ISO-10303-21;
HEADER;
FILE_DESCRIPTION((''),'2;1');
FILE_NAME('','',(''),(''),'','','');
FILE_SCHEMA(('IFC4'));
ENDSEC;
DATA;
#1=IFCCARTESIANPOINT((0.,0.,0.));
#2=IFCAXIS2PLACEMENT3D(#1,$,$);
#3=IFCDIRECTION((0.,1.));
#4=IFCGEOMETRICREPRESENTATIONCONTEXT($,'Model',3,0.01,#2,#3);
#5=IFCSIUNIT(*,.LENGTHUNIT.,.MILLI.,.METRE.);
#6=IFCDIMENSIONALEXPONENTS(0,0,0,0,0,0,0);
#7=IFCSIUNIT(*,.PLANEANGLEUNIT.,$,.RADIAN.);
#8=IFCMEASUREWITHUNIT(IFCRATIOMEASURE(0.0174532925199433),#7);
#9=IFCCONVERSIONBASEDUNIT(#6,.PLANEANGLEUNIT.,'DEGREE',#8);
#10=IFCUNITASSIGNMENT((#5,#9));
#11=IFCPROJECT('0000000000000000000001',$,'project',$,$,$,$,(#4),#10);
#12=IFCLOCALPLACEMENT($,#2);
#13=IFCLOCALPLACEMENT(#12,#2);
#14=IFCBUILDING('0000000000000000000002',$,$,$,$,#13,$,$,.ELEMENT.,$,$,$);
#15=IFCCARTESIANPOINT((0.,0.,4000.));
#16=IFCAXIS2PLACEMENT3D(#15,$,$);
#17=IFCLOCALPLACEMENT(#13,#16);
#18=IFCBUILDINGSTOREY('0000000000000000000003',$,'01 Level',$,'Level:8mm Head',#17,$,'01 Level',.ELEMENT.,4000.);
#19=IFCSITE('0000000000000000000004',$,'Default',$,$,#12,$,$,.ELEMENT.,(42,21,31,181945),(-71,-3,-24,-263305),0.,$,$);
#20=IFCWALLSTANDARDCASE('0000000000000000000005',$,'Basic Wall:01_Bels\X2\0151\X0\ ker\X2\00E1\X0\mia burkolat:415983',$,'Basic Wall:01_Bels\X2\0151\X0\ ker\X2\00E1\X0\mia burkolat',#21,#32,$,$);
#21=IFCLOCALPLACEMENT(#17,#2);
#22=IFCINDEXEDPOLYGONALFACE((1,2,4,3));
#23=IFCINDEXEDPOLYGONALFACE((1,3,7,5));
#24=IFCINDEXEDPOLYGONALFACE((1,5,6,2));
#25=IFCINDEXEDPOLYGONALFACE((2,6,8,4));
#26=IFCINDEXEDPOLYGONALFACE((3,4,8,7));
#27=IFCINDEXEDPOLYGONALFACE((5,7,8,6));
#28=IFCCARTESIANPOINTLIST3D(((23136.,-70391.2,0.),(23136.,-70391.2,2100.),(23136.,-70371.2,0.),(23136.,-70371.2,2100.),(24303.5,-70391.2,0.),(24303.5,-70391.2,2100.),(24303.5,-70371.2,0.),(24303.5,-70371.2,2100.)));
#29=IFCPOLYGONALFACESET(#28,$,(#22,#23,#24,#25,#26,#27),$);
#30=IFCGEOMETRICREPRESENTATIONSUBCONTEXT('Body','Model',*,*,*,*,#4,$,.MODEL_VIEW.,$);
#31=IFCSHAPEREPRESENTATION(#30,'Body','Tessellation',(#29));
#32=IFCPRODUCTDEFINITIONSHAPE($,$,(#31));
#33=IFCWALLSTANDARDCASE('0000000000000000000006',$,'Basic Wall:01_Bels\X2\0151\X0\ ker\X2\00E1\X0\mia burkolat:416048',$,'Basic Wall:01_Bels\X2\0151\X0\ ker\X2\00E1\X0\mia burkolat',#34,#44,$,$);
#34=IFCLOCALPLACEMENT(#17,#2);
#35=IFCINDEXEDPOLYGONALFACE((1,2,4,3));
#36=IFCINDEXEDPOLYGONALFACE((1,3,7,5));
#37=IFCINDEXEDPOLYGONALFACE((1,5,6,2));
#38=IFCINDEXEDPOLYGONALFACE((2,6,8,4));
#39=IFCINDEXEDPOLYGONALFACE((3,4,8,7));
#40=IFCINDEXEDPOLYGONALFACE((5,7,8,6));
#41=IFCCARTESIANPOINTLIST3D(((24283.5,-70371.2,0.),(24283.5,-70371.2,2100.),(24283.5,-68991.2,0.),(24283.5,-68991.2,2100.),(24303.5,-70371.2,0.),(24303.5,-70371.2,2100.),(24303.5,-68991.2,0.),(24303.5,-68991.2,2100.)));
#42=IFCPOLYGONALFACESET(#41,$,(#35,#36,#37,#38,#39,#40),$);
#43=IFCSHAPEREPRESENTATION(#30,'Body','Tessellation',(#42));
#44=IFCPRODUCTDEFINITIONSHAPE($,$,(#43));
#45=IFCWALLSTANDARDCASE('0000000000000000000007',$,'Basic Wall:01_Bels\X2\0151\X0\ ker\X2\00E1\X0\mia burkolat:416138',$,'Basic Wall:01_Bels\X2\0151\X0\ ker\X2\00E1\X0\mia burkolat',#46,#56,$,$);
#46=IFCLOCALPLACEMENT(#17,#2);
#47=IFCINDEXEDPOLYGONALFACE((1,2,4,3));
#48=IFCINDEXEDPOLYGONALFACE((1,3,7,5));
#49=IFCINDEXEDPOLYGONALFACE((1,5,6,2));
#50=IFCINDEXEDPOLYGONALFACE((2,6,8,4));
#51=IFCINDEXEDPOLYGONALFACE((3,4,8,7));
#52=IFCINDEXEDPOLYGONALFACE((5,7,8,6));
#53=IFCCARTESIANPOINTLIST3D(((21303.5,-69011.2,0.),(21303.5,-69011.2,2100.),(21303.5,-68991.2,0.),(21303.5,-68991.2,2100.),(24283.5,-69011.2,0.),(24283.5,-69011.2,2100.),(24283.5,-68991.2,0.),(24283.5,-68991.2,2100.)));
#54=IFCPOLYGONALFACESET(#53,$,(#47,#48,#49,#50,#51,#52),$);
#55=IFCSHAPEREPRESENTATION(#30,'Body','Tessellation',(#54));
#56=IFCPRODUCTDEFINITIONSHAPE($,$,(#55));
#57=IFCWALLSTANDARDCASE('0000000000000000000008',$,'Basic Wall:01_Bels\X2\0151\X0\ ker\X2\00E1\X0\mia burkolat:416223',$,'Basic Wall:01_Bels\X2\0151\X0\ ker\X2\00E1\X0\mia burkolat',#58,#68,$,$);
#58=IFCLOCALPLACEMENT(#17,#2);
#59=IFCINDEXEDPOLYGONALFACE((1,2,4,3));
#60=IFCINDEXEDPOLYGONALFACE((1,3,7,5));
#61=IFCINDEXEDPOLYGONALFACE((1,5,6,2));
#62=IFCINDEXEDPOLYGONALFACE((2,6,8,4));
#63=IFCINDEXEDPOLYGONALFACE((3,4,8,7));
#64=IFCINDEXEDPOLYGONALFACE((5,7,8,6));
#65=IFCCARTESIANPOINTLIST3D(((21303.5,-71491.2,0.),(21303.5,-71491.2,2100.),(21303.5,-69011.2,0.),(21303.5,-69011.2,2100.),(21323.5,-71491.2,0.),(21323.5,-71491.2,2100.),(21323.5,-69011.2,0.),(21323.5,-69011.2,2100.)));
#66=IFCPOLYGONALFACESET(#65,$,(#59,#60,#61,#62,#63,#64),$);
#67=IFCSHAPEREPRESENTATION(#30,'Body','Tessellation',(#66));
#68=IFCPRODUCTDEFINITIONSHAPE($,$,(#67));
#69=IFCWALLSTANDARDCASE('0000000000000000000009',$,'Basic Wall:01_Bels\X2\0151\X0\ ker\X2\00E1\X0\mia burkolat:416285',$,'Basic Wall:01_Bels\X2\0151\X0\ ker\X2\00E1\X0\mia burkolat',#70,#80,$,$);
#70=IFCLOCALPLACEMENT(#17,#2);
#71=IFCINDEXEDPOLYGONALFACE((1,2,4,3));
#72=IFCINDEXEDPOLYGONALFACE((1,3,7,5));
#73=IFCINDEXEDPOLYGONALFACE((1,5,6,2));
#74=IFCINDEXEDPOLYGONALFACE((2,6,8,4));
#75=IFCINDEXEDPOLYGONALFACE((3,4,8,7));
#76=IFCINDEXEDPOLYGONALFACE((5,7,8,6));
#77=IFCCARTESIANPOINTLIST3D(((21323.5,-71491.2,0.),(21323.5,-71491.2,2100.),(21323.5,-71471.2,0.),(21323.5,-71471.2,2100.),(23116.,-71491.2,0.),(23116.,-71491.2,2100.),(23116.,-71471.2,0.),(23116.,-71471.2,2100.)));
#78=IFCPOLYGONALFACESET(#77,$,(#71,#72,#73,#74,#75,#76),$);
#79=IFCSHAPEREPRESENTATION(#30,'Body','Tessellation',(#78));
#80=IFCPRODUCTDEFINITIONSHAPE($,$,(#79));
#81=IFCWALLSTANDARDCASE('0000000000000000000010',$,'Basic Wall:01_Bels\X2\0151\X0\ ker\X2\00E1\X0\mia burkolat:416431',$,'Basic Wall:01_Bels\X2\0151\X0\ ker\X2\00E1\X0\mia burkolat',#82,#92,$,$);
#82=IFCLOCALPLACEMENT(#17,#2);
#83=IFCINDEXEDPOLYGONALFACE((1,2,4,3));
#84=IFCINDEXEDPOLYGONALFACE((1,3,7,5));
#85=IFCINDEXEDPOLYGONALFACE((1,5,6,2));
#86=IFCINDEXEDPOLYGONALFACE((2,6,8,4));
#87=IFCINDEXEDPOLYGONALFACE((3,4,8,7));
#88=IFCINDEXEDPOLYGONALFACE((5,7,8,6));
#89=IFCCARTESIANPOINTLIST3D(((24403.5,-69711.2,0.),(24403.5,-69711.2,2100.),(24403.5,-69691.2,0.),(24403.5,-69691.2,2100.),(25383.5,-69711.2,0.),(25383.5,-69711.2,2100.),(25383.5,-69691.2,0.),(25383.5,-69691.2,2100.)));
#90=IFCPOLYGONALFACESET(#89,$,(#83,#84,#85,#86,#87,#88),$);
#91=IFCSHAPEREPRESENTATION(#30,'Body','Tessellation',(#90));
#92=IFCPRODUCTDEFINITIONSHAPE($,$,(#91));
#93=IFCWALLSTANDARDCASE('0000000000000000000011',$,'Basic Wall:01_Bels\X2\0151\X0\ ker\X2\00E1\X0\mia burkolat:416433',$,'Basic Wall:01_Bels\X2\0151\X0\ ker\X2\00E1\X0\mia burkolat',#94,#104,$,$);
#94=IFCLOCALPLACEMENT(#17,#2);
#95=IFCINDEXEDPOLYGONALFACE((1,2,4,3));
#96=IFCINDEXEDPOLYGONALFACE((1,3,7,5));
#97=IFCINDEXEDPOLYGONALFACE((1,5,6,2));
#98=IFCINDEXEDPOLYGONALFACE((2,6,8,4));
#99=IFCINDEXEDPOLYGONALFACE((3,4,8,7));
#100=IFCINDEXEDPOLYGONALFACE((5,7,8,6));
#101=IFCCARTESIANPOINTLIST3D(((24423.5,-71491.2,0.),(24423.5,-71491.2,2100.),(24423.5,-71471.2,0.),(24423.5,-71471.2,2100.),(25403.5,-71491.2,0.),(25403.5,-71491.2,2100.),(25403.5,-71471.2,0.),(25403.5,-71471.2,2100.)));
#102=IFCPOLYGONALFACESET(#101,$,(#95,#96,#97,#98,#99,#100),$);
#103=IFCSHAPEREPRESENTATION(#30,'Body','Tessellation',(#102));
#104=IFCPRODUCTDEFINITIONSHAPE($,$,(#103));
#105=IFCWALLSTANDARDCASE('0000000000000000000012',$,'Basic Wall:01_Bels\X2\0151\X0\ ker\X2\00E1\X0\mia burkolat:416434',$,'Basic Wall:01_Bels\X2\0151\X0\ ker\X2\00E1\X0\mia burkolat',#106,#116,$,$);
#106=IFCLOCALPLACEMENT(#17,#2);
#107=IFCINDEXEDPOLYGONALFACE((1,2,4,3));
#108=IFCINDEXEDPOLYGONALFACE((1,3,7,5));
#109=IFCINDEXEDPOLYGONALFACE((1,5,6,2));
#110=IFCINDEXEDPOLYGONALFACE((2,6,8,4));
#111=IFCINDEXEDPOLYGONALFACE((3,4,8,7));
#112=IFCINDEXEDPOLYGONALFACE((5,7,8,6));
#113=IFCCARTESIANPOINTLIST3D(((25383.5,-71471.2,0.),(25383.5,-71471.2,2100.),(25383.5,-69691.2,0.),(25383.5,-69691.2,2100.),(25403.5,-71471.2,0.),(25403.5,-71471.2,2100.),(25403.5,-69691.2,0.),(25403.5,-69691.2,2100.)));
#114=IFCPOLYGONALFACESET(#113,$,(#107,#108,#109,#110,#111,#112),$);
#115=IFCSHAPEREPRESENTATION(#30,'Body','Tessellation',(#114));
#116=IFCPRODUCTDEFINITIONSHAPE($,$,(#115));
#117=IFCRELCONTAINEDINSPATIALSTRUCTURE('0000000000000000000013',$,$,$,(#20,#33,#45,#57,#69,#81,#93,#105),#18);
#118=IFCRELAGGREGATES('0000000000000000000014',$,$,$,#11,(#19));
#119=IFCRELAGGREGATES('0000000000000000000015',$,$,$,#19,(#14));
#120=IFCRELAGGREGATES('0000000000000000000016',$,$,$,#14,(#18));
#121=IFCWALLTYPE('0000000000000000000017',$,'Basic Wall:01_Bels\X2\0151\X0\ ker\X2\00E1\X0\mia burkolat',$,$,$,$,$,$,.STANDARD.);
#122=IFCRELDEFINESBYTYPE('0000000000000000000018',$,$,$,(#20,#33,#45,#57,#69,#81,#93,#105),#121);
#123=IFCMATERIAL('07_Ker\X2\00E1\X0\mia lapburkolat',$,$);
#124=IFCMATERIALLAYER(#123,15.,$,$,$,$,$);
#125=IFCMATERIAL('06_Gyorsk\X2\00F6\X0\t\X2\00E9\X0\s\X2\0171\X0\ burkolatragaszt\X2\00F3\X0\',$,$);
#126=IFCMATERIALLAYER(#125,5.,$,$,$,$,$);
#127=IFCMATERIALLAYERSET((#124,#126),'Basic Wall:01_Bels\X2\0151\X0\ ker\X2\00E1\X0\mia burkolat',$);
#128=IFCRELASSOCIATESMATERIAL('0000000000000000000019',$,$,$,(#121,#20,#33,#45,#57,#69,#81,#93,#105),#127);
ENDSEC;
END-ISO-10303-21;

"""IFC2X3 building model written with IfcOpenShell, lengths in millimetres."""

from ifc_helpers import new_model, entity, si_unit, converted_unit, direction, frame, frame_2d, origin, place, context, subcontext, project, spatial, rectangle, extrude, material, layer, layer_set, layer_usage, type_object, element, save


model = new_model("IFC2X3")

# Units and contexts
model_context = context("Model", 3, precision=0.01, world=origin(), true_north=direction((0.0, 1.0)))
body_context = subcontext(model_context, "Body", "Model", "MODEL_VIEW")
ifc_project = project(units=[si_unit("LENGTHUNIT", "METRE", prefix="MILLI"), converted_unit("PLANEANGLEUNIT", "DEGREE", entity("IfcRatioMeasure", 0.0174532925199433), si_unit("PLANEANGLEUNIT", "RADIAN"), dimensions=[0, 0, 0, 0, 0, 0, 0])], contexts=[model_context])

# Site, building, storey
site_placement = place(None, origin())
site = spatial("IfcSite", under=ifc_project, at=site_placement, Name="Default", CompositionType="ELEMENT", RefLatitude=(42, 21, 31, 181945), RefLongitude=(-71, -3, -24, -263305), RefElevation=0.0)
building_placement = place(site_placement, origin())
building = spatial("IfcBuilding", under=site, at=building_placement, CompositionType="ELEMENT")
storey_placement = place(building_placement, frame((0.0, 0.0, 4000.0)))
storey = spatial("IfcBuildingStorey", under=building, at=storey_placement, Name="01 Level", ObjectType="Level:8mm Head", LongName="01 Level", CompositionType="ELEMENT", Elevation=4000.0)

# Shared definitions
ifc_material_1 = material(Name="07_Kerámia lapburkolat")
ifc_layer_1 = layer(ifc_material_1, 15.0)
ifc_material_2 = material(Name="06_Gyorskötésű burkolatragasztó")
ifc_layer_2 = layer(ifc_material_2, 5.0)
ifc_layer_set_1 = layer_set([ifc_layer_1, ifc_layer_2], Name="Basic Wall:01_Belső kerámia burkolat")
wall_type_1 = type_object("IfcWallType", Name="Basic Wall:01_Belső kerámia burkolat", PredefinedType="STANDARD", material=ifc_layer_set_1)

# Walls
ifc_layer_usage_1 = layer_usage(ifc_layer_set_1, "AXIS2", "NEGATIVE", 10.0)
wall_1_placement = place(storey_placement, frame((23136.0, -70381.2, 0.0)))
element("IfcWallStandardCase", 1, at=wall_1_placement, inside=storey, type_object=wall_type_1, material=ifc_layer_usage_1, Name="Basic Wall:01_Belső kerámia burkolat:415983", ObjectType="Basic Wall:01_Belső kerámia burkolat", context=body_context, shape_type="SweptSolid", body=[
    extrude(rectangle(XDim=1167.5, YDim=20.0, at=frame_2d((583.7, 0.0), x_axis=(-1.0, 0.0))), origin(), (0.0, 0.0, 1.0), 2100.0),
])
ifc_layer_usage_2 = layer_usage(ifc_layer_set_1, "AXIS2", "NEGATIVE", 10.0)
wall_2_placement = place(storey_placement, frame((24293.5, -70371.2, 0.0), z_axis=(0.0, 0.0, 1.0), x_axis=(0.0, 1.0, 0.0)))
element("IfcWallStandardCase", 2, at=wall_2_placement, inside=storey, type_object=wall_type_1, material=ifc_layer_usage_2, Name="Basic Wall:01_Belső kerámia burkolat:416048", ObjectType="Basic Wall:01_Belső kerámia burkolat", context=body_context, shape_type="SweptSolid", body=[
    extrude(rectangle(XDim=1380.0, YDim=20.0, at=frame_2d((690.0, 0.0), x_axis=(-1.0, 0.0))), origin(), (0.0, 0.0, 1.0), 2100.0),
])
ifc_layer_usage_3 = layer_usage(ifc_layer_set_1, "AXIS2", "NEGATIVE", 10.0)
wall_3_placement = place(storey_placement, frame((24283.5, -69001.2, 0.0), z_axis=(0.0, 0.0, 1.0), x_axis=(-1.0, 0.0, 0.0)))
element("IfcWallStandardCase", 3, at=wall_3_placement, inside=storey, type_object=wall_type_1, material=ifc_layer_usage_3, Name="Basic Wall:01_Belső kerámia burkolat:416138", ObjectType="Basic Wall:01_Belső kerámia burkolat", context=body_context, shape_type="SweptSolid", body=[
    extrude(rectangle(XDim=2980.0, YDim=20.0, at=frame_2d((1490.0, 0.0), x_axis=(-1.0, 0.0))), origin(), (0.0, 0.0, 1.0), 2100.0),
])
ifc_layer_usage_4 = layer_usage(ifc_layer_set_1, "AXIS2", "NEGATIVE", 10.0)
wall_4_placement = place(storey_placement, frame((21313.5, -69011.2, 0.0), z_axis=(0.0, 0.0, 1.0), x_axis=(0.0, -1.0, 0.0)))
element("IfcWallStandardCase", 4, at=wall_4_placement, inside=storey, type_object=wall_type_1, material=ifc_layer_usage_4, Name="Basic Wall:01_Belső kerámia burkolat:416223", ObjectType="Basic Wall:01_Belső kerámia burkolat", context=body_context, shape_type="SweptSolid", body=[
    extrude(rectangle(XDim=2480.0, YDim=20.0, at=frame_2d((1240.0, 0.0), x_axis=(-1.0, 0.0))), origin(), (0.0, 0.0, 1.0), 2100.0),
])
ifc_layer_usage_5 = layer_usage(ifc_layer_set_1, "AXIS2", "NEGATIVE", 10.0)
wall_5_placement = place(storey_placement, frame((21323.5, -71481.2, 0.0)))
element("IfcWallStandardCase", 5, at=wall_5_placement, inside=storey, type_object=wall_type_1, material=ifc_layer_usage_5, Name="Basic Wall:01_Belső kerámia burkolat:416285", ObjectType="Basic Wall:01_Belső kerámia burkolat", context=body_context, shape_type="SweptSolid", body=[
    extrude(rectangle(XDim=1792.5, YDim=20.0, at=frame_2d((896.3, 0.0), x_axis=(-1.0, 0.0))), origin(), (0.0, 0.0, 1.0), 2100.0),
])
ifc_layer_usage_6 = layer_usage(ifc_layer_set_1, "AXIS2", "POSITIVE", -10.0)
wall_6_placement = place(storey_placement, frame((24403.5, -69701.2, 0.0)))
element("IfcWallStandardCase", 6, at=wall_6_placement, inside=storey, type_object=wall_type_1, material=ifc_layer_usage_6, Name="Basic Wall:01_Belső kerámia burkolat:416431", ObjectType="Basic Wall:01_Belső kerámia burkolat", context=body_context, shape_type="SweptSolid", body=[
    extrude(rectangle(XDim=980.0, YDim=20.0, at=frame_2d((490.0, 0.0), x_axis=(-1.0, 0.0))), origin(), (0.0, 0.0, 1.0), 2100.0),
])

# Walls
ifc_layer_usage_7 = layer_usage(ifc_layer_set_1, "AXIS2", "POSITIVE", -10.0)
wall_7_placement = place(storey_placement, frame((25403.5, -71481.2, 0.0), z_axis=(0.0, 0.0, 1.0), x_axis=(-1.0, 0.0, 0.0)))
element("IfcWallStandardCase", 7, at=wall_7_placement, inside=storey, type_object=wall_type_1, material=ifc_layer_usage_7, Name="Basic Wall:01_Belső kerámia burkolat:416433", ObjectType="Basic Wall:01_Belső kerámia burkolat", context=body_context, shape_type="SweptSolid", body=[
    extrude(rectangle(XDim=980.0, YDim=20.0, at=frame_2d((490.0, 0.0), x_axis=(-1.0, 0.0))), origin(), (0.0, 0.0, 1.0), 2100.0),
])
ifc_layer_usage_8 = layer_usage(ifc_layer_set_1, "AXIS2", "POSITIVE", -10.0)
wall_8_placement = place(storey_placement, frame((25393.5, -69691.2, 0.0), z_axis=(0.0, 0.0, 1.0), x_axis=(0.0, -1.0, 0.0)))
element("IfcWallStandardCase", 8, at=wall_8_placement, inside=storey, type_object=wall_type_1, material=ifc_layer_usage_8, Name="Basic Wall:01_Belső kerámia burkolat:416434", ObjectType="Basic Wall:01_Belső kerámia burkolat", context=body_context, shape_type="SweptSolid", body=[
    extrude(rectangle(XDim=1780.0, YDim=20.0, at=frame_2d((890.0, 0.0), x_axis=(-1.0, 0.0))), origin(), (0.0, 0.0, 1.0), 2100.0),
])

save(model, "model.ifc")
